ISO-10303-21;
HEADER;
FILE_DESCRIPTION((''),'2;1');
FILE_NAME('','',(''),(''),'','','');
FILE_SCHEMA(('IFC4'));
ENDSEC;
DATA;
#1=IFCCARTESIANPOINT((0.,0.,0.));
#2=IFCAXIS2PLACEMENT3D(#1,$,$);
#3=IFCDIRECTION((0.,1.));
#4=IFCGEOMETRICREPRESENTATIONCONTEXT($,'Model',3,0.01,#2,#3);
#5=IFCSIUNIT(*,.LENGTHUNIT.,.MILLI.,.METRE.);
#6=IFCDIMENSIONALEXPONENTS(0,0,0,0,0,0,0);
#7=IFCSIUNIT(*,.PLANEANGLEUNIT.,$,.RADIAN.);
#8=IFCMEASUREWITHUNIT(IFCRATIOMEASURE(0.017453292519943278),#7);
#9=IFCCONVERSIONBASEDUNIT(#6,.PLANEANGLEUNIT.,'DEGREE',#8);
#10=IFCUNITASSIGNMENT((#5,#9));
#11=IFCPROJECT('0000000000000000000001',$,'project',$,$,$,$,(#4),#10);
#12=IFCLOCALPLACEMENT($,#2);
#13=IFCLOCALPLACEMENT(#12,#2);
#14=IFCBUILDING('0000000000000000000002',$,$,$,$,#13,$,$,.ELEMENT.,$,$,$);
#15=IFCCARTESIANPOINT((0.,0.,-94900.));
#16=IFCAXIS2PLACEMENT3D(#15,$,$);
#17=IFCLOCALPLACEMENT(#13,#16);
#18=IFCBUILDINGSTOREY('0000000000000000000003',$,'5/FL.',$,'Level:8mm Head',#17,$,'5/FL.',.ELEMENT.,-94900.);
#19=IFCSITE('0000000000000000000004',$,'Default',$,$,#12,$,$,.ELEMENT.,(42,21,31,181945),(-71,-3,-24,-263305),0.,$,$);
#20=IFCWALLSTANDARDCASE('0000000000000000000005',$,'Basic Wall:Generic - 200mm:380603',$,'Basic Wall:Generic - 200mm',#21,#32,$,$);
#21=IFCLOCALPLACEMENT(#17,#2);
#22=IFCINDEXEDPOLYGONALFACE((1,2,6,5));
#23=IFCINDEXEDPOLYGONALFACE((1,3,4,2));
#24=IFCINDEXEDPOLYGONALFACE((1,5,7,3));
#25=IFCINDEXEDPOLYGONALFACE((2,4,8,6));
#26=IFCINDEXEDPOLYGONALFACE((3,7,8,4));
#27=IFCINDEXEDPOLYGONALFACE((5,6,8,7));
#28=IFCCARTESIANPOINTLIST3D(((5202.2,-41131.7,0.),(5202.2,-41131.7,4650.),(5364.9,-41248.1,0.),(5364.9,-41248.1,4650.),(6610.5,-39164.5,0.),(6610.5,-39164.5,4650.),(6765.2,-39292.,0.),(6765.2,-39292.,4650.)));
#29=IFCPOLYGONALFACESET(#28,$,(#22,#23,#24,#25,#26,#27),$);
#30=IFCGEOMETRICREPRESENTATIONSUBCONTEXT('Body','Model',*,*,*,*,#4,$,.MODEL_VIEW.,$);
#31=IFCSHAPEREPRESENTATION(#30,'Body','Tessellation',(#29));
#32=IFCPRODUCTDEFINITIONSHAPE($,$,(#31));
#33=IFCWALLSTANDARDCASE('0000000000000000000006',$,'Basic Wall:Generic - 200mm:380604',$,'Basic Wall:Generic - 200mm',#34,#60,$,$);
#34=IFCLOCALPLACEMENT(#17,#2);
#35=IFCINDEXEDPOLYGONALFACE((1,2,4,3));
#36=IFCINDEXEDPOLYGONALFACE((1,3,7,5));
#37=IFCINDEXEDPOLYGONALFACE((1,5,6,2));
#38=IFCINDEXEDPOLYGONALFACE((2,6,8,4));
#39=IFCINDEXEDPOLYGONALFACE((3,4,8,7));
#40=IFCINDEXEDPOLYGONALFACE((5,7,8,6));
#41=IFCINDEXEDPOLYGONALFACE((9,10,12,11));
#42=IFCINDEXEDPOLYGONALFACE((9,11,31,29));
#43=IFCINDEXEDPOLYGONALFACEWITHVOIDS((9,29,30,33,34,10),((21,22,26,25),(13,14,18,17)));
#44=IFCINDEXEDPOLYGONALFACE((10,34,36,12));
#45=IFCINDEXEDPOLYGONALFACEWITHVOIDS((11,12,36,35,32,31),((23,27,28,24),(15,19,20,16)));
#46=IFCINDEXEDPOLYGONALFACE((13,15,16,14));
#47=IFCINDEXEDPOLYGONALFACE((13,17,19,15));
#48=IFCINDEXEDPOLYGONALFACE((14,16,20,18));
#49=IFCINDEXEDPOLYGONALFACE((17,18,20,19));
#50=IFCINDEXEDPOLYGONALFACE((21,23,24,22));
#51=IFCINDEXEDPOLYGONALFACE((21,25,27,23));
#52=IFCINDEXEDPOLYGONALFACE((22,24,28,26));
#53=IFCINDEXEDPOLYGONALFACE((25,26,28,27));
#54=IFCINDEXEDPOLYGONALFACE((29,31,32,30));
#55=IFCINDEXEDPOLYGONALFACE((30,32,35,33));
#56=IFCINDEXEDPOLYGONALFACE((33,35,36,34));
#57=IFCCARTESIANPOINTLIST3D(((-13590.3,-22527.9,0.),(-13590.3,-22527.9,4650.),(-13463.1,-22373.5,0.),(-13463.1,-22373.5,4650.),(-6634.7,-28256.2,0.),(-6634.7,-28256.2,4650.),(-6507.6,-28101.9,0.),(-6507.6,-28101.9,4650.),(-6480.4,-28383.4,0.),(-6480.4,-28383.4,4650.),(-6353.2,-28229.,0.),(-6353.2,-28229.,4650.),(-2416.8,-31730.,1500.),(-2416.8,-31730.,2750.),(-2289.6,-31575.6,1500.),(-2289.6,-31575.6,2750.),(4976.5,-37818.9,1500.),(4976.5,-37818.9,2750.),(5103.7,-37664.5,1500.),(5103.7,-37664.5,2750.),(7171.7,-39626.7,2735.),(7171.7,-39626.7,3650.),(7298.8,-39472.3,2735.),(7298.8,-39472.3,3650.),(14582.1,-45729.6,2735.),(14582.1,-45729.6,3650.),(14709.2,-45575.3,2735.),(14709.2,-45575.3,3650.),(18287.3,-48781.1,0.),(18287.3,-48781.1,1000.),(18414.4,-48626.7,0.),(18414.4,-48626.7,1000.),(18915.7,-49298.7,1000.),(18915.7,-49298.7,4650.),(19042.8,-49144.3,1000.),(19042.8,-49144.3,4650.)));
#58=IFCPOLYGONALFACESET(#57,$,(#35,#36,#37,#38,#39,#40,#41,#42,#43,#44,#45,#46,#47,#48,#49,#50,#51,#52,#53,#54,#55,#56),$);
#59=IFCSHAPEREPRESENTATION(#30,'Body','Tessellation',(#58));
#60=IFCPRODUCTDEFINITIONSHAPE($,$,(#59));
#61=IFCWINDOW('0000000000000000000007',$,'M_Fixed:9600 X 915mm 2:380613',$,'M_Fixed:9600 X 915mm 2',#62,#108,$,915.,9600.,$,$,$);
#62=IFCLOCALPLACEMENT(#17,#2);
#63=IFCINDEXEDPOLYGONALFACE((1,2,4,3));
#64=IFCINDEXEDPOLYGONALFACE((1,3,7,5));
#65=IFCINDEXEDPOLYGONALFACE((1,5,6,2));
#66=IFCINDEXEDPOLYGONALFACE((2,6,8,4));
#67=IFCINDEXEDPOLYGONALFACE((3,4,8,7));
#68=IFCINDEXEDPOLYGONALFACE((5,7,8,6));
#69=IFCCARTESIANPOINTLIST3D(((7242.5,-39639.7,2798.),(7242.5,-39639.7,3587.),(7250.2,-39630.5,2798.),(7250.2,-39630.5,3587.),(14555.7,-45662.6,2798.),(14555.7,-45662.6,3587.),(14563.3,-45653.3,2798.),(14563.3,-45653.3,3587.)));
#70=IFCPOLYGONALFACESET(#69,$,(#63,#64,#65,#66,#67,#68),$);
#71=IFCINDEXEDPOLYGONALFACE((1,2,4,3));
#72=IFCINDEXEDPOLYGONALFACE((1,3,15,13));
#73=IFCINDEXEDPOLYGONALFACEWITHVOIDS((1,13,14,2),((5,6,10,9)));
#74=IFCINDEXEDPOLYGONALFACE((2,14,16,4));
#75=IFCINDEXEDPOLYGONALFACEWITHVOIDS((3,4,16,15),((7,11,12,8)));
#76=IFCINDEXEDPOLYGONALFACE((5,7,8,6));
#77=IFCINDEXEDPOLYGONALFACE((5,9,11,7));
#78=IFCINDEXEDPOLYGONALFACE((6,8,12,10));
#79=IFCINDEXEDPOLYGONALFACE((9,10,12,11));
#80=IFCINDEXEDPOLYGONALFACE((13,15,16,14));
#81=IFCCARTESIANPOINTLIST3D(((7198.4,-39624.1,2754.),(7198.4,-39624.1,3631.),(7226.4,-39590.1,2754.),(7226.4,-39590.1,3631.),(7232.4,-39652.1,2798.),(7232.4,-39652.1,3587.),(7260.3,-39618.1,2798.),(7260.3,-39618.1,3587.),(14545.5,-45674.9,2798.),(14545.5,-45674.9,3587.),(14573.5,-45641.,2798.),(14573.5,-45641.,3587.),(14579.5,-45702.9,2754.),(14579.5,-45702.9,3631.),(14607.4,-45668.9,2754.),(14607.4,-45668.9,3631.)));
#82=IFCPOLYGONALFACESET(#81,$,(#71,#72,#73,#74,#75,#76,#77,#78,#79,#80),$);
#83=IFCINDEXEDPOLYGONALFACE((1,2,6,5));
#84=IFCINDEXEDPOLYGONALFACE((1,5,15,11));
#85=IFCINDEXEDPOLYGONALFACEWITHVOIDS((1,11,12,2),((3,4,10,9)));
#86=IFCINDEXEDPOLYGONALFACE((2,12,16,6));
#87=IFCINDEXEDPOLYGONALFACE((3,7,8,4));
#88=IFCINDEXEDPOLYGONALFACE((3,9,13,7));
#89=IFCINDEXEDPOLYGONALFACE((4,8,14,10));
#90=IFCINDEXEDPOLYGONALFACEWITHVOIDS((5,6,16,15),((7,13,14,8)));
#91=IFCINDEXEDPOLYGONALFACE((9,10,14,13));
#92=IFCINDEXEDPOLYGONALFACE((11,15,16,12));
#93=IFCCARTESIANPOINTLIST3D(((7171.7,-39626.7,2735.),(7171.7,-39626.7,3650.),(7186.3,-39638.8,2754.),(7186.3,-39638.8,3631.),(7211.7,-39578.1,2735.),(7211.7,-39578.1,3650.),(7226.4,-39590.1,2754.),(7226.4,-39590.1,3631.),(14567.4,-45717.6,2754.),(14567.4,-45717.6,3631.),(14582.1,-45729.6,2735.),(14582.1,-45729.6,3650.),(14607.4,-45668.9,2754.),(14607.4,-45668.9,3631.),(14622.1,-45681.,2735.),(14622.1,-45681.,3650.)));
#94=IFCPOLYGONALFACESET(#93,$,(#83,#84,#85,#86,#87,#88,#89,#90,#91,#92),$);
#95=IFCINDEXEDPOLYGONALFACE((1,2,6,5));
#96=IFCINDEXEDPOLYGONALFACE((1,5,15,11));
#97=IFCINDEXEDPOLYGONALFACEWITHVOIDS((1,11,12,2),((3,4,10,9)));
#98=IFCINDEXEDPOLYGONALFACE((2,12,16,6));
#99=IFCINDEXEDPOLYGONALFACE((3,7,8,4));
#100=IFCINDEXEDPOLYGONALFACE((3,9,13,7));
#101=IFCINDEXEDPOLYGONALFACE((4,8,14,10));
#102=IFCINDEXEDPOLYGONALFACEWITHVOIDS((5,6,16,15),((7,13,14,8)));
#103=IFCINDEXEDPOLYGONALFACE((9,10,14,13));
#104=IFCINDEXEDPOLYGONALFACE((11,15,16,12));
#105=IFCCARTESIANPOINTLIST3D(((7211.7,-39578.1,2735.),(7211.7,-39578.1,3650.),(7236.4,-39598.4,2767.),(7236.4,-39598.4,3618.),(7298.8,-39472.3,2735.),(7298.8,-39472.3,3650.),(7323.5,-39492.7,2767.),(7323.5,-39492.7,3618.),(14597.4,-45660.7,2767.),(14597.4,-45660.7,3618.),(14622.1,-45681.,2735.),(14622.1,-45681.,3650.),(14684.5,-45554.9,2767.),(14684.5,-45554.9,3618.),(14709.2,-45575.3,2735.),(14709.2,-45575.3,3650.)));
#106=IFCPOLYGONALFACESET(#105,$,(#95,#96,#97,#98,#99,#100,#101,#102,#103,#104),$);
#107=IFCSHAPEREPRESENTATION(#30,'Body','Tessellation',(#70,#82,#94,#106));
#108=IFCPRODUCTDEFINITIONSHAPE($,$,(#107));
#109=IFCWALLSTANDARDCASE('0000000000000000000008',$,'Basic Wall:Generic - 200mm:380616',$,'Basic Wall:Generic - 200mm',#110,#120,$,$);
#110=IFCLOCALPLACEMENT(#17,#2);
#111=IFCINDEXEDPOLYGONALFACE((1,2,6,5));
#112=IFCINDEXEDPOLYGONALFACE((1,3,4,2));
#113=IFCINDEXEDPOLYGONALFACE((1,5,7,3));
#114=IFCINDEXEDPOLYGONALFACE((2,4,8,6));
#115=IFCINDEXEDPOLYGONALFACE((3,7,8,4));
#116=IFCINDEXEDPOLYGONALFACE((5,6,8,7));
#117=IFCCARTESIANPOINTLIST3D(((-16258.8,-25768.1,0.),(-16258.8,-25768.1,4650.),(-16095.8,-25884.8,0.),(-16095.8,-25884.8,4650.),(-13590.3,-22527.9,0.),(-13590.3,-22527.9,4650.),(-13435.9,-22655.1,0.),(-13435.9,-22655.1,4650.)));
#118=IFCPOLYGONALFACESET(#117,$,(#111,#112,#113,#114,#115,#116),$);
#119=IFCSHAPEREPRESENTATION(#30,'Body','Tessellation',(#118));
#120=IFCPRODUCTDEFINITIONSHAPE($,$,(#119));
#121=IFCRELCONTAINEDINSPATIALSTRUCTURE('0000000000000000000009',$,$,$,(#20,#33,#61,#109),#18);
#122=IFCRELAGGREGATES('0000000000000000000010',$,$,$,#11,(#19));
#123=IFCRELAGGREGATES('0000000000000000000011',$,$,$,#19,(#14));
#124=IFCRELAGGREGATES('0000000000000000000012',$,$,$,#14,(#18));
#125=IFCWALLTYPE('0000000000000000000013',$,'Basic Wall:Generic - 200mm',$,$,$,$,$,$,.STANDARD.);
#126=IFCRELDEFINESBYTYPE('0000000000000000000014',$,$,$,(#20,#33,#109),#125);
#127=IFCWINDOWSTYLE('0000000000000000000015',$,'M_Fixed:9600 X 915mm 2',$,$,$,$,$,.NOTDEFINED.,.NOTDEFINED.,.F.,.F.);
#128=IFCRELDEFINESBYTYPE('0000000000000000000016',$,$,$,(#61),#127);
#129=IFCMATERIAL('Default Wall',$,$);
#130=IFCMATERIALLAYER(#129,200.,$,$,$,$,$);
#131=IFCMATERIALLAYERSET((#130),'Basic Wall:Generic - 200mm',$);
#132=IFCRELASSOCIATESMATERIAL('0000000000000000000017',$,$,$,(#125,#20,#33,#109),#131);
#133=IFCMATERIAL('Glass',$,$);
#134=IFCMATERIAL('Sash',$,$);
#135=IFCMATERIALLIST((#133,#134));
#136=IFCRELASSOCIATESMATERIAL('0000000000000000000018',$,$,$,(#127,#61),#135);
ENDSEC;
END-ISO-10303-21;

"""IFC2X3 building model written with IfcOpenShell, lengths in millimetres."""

from ifc_helpers import new_model, entity, si_unit, converted_unit, direction, frame, frame_2d, origin, place, context, subcontext, project, spatial, polyline, rectangle, outline, extrude, source, transform, mapped, material, material_list, layer, layer_set, layer_usage, type_object, type_shapes, element, fill, save


model = new_model("IFC2X3")

# Units and contexts
model_context = context("Model", 3, precision=0.01, world=origin(), true_north=direction((0.0, 1.0)))
body_context = subcontext(model_context, "Body", "Model", "MODEL_VIEW")
ifc_project = project(units=[si_unit("LENGTHUNIT", "METRE", prefix="MILLI"), converted_unit("PLANEANGLEUNIT", "DEGREE", entity("IfcRatioMeasure", 0.017453292519943278), si_unit("PLANEANGLEUNIT", "RADIAN"), dimensions=[0, 0, 0, 0, 0, 0, 0])], contexts=[model_context])

# Site, building, storey
site_placement = place(None, origin())
site = spatial("IfcSite", under=ifc_project, at=site_placement, Name="Default", CompositionType="ELEMENT", RefLatitude=(42, 21, 31, 181945), RefLongitude=(-71, -3, -24, -263305), RefElevation=0.0)
building_placement = place(site_placement, origin())
building = spatial("IfcBuilding", under=site, at=building_placement, CompositionType="ELEMENT")
storey_placement = place(building_placement, frame((0.0, 0.0, -94900.0)))
storey = spatial("IfcBuildingStorey", under=building, at=storey_placement, Name="5/FL.", ObjectType="Level:8mm Head", LongName="5/FL.", CompositionType="ELEMENT", Elevation=-94900.0)

# Shared definitions
ifc_material_1 = material(Name="Default Wall")
ifc_layer = layer(ifc_material_1, 200.0)
ifc_layer_set = layer_set([ifc_layer], Name="Basic Wall:Generic - 200mm")
ifc_layer_usage = layer_usage(ifc_layer_set, "AXIS2", "NEGATIVE", 100.0)
wall_type = type_object("IfcWallType", Name="Basic Wall:Generic - 200mm", PredefinedType="STANDARD", material=ifc_layer_set)

# Shared definitions
ifc_material_2 = material(Name="Glass")
ifc_material_3 = material(Name="Sash")
ifc_material_list = material_list([ifc_material_2, ifc_material_3])

# Wall
wall_1_placement = place(storey_placement, frame((5283.5, -41189.9, 0.0), z_axis=(0.0, 0.0, 1.0), x_axis=(0.582098, 0.813119, 0.0)))
element("IfcWallStandardCase", 1, at=wall_1_placement, inside=storey, type_object=wall_type, material=ifc_layer_usage, Name="Basic Wall:Generic - 200mm:380603", ObjectType="Basic Wall:Generic - 200mm", context=body_context, shape_type="SweptSolid", body=[
    extrude(outline(polyline([(2405.7, -100.0), (2419.3, 100.0), (0.0, 100.0), (0.0, -100.0), (2405.7, -100.0)])), origin(), (0.0, 0.0, 1.0), 4650.0),
])

# Wall, openings, window
wall_2_placement = place(storey_placement, frame((-13526.7, -22450.7, 0.0), z_axis=(0.0, 0.0, 1.0), x_axis=(0.771917, -0.635723, 0.0)))
wall_2 = element("IfcWallStandardCase", 2, at=wall_2_placement, inside=storey, type_object=wall_type, material=ifc_layer_usage, Name="Basic Wall:Generic - 200mm:380604", ObjectType="Basic Wall:Generic - 200mm", context=body_context, shape_type="SweptSolid", body=[
    extrude(rectangle(XDim=42110.7, YDim=200.0, at=frame_2d((21055.3, 0.0), x_axis=(-1.0, 0.0))), origin(), (0.0, 0.0, 1.0), 4650.0),
])
opening_1_placement = place(storey_placement, frame((-13526.7, -22450.7, 0.0), z_axis=(0.0, 0.0, 1.0), x_axis=(0.771917, -0.635723, 0.0)))
element("IfcOpeningElement", 3, at=opening_1_placement, cuts=wall_2, ObjectType="Opening", context=body_context, shape_type="SweptSolid", body=[
    extrude(rectangle(XDim=4650.0, YDim=200.0, at=frame_2d((0.0, 0.0), x_axis=(1.0, 0.0))), frame((9210.7, 0.0, 2325.0), z_axis=(-1.0, 0.0, 0.0), x_axis=(0.0, 0.0, 1.0)), (0.0, 0.0, 1.0), 200.0),
])
opening_2_placement = place(wall_2_placement, origin())
element("IfcOpeningElement", 4, at=opening_2_placement, cuts=wall_2, ObjectType="Opening", context=body_context, shape_type="SweptSolid", body=[
    extrude(rectangle(XDim=1250.0, YDim=9577.8, at=frame_2d((0.0, 0.0), x_axis=(1.0, 0.0))), frame((19263.9, -100.0, 2125.0), z_axis=(0.0, 1.0, 0.0), x_axis=(0.0, 0.0, -1.0)), (0.0, 0.0, 1.0), 200.0),
])
opening_3_placement = place(wall_2_placement, frame((-3831.0, 25929.3, 0.0), z_axis=(0.0, 0.0, 1.0), x_axis=(0.771917, 0.635723, 0.0)))
element("IfcOpeningElement", 5, at=opening_3_placement, cuts=wall_2, ObjectType="Opening", context=body_context, shape_type="SweptSolid", body=[
    extrude(rectangle(XDim=1000.0, YDim=1010.1, at=frame_2d((0.0, 0.0), x_axis=(1.0, 0.0))), frame((18669.0, -49112.0, 500.0), z_axis=(0.635723, 0.771917, 0.0), x_axis=(0.0, 0.0, -1.0)), (0.0, 0.0, 1.0), 1012.7),
])
opening_4_placement = place(wall_2_placement, frame((36496.6, 100.0, 2735.0)))
opening_4 = element("IfcOpeningElement", 6, at=opening_4_placement, cuts=wall_2, ObjectType="Opening", context=body_context, shape_type="SweptSolid", body=[
    extrude(rectangle(XDim=915.0, YDim=9600.0, at=frame_2d((457.5, 4800.0), x_axis=(1.0, 0.0))), frame((0.0, 0.0, 0.0), z_axis=(0.0, -1.0, 0.0), x_axis=(0.0, 0.0, 1.0)), (0.0, 0.0, 1.0), 200.0),
])
window_style_1 = type_object("IfcWindowStyle", Name="M_Fixed:9600 X 915mm 2", ConstructionType="NOTDEFINED", OperationType="NOTDEFINED", ParameterTakesPrecedence=False, Sizeable=False, material=ifc_material_list)
shared_shape_1 = source(origin(), body_context, "Body", "SweptSolid", [
    extrude(rectangle(XDim=12.0, YDim=9474.0, at=frame_2d((0.0, 0.0), x_axis=(1.0, 0.0))), frame((4800.0, 159.0, 63.0), z_axis=(0.0, 0.0, 1.0), x_axis=(0.0, -1.0, 0.0)), (0.0, 0.0, 1.0), 789.0),
    extrude(outline(polyline([(-4781.0, -438.5), (4781.0, -438.5), (4781.0, 438.5), (-4781.0, 438.5), (-4781.0, -438.5)]), holes=[polyline([(-4737.0, -394.5), (-4737.0, 394.5), (4737.0, 394.5), (4737.0, -394.5), (-4737.0, -394.5)])]), frame((4800.0, 137.0, 457.5), z_axis=(0.0, 1.0, 0.0), x_axis=(1.0, 0.0, 0.0)), (0.0, 0.0, 1.0), 44.0),
    extrude(outline(polyline([(-4800.0, -457.5), (4800.0, -457.5), (4800.0, 457.5), (-4800.0, 457.5), (-4800.0, -457.5)]), holes=[polyline([(-4781.0, -438.5), (-4781.0, 438.5), (4781.0, 438.5), (4781.0, -438.5), (-4781.0, -438.5)])]), frame((4800.0, 137.0, 457.5), z_axis=(0.0, 1.0, 0.0), x_axis=(1.0, 0.0, 0.0)), (0.0, 0.0, 1.0), 63.0),
    extrude(outline(polyline([(-4800.0, -457.5), (4800.0, -457.5), (4800.0, 457.5), (-4800.0, 457.5), (-4800.0, -457.5)]), holes=[polyline([(-4768.0, -425.5), (-4768.0, 425.5), (4768.0, 425.5), (4768.0, -425.5), (-4768.0, -425.5)])]), frame((4800.0, 0.0, 457.5), z_axis=(0.0, 1.0, 0.0), x_axis=(1.0, 0.0, 0.0)), (0.0, 0.0, 1.0), 137.0),
])
type_shapes(window_style_1, [shared_shape_1])
window_1_placement = place(opening_4_placement, frame((0.0, 0.0, 0.0), z_axis=(0.0, 0.0, 1.0), x_axis=(-1.0, 0.0, 0.0)))
window_1 = element("IfcWindow", 7, at=window_1_placement, inside=storey, type_object=window_style_1, material=ifc_material_list, Name="M_Fixed:9600 X 915mm 2:380613", ObjectType="M_Fixed:9600 X 915mm 2", OverallHeight=915.0, OverallWidth=9600.0, context=body_context, shape_type="MappedRepresentation", body=[
    mapped(shared_shape_1, transform((0.0, 0.0, 0.0), scale=1.0)),
])
fill(opening_4, window_1)

# Wall
wall_3_placement = place(storey_placement, frame((-16181.6, -25831.7, 0.0), z_axis=(0.0, 0.0, 1.0), x_axis=(0.635723, 0.771917, 0.0)))
element("IfcWallStandardCase", 8, at=wall_3_placement, inside=storey, type_object=wall_type, material=ifc_layer_usage, Name="Basic Wall:Generic - 200mm:380616", ObjectType="Basic Wall:Generic - 200mm", context=body_context, shape_type="SweptSolid", body=[
    extrude(outline(polyline([(4197.6, -100.0), (4197.6, 100.0), (0.0, 100.0), (13.5, -100.0), (4197.6, -100.0)])), origin(), (0.0, 0.0, 1.0), 4650.0),
])

save(model, "model.ifc")
